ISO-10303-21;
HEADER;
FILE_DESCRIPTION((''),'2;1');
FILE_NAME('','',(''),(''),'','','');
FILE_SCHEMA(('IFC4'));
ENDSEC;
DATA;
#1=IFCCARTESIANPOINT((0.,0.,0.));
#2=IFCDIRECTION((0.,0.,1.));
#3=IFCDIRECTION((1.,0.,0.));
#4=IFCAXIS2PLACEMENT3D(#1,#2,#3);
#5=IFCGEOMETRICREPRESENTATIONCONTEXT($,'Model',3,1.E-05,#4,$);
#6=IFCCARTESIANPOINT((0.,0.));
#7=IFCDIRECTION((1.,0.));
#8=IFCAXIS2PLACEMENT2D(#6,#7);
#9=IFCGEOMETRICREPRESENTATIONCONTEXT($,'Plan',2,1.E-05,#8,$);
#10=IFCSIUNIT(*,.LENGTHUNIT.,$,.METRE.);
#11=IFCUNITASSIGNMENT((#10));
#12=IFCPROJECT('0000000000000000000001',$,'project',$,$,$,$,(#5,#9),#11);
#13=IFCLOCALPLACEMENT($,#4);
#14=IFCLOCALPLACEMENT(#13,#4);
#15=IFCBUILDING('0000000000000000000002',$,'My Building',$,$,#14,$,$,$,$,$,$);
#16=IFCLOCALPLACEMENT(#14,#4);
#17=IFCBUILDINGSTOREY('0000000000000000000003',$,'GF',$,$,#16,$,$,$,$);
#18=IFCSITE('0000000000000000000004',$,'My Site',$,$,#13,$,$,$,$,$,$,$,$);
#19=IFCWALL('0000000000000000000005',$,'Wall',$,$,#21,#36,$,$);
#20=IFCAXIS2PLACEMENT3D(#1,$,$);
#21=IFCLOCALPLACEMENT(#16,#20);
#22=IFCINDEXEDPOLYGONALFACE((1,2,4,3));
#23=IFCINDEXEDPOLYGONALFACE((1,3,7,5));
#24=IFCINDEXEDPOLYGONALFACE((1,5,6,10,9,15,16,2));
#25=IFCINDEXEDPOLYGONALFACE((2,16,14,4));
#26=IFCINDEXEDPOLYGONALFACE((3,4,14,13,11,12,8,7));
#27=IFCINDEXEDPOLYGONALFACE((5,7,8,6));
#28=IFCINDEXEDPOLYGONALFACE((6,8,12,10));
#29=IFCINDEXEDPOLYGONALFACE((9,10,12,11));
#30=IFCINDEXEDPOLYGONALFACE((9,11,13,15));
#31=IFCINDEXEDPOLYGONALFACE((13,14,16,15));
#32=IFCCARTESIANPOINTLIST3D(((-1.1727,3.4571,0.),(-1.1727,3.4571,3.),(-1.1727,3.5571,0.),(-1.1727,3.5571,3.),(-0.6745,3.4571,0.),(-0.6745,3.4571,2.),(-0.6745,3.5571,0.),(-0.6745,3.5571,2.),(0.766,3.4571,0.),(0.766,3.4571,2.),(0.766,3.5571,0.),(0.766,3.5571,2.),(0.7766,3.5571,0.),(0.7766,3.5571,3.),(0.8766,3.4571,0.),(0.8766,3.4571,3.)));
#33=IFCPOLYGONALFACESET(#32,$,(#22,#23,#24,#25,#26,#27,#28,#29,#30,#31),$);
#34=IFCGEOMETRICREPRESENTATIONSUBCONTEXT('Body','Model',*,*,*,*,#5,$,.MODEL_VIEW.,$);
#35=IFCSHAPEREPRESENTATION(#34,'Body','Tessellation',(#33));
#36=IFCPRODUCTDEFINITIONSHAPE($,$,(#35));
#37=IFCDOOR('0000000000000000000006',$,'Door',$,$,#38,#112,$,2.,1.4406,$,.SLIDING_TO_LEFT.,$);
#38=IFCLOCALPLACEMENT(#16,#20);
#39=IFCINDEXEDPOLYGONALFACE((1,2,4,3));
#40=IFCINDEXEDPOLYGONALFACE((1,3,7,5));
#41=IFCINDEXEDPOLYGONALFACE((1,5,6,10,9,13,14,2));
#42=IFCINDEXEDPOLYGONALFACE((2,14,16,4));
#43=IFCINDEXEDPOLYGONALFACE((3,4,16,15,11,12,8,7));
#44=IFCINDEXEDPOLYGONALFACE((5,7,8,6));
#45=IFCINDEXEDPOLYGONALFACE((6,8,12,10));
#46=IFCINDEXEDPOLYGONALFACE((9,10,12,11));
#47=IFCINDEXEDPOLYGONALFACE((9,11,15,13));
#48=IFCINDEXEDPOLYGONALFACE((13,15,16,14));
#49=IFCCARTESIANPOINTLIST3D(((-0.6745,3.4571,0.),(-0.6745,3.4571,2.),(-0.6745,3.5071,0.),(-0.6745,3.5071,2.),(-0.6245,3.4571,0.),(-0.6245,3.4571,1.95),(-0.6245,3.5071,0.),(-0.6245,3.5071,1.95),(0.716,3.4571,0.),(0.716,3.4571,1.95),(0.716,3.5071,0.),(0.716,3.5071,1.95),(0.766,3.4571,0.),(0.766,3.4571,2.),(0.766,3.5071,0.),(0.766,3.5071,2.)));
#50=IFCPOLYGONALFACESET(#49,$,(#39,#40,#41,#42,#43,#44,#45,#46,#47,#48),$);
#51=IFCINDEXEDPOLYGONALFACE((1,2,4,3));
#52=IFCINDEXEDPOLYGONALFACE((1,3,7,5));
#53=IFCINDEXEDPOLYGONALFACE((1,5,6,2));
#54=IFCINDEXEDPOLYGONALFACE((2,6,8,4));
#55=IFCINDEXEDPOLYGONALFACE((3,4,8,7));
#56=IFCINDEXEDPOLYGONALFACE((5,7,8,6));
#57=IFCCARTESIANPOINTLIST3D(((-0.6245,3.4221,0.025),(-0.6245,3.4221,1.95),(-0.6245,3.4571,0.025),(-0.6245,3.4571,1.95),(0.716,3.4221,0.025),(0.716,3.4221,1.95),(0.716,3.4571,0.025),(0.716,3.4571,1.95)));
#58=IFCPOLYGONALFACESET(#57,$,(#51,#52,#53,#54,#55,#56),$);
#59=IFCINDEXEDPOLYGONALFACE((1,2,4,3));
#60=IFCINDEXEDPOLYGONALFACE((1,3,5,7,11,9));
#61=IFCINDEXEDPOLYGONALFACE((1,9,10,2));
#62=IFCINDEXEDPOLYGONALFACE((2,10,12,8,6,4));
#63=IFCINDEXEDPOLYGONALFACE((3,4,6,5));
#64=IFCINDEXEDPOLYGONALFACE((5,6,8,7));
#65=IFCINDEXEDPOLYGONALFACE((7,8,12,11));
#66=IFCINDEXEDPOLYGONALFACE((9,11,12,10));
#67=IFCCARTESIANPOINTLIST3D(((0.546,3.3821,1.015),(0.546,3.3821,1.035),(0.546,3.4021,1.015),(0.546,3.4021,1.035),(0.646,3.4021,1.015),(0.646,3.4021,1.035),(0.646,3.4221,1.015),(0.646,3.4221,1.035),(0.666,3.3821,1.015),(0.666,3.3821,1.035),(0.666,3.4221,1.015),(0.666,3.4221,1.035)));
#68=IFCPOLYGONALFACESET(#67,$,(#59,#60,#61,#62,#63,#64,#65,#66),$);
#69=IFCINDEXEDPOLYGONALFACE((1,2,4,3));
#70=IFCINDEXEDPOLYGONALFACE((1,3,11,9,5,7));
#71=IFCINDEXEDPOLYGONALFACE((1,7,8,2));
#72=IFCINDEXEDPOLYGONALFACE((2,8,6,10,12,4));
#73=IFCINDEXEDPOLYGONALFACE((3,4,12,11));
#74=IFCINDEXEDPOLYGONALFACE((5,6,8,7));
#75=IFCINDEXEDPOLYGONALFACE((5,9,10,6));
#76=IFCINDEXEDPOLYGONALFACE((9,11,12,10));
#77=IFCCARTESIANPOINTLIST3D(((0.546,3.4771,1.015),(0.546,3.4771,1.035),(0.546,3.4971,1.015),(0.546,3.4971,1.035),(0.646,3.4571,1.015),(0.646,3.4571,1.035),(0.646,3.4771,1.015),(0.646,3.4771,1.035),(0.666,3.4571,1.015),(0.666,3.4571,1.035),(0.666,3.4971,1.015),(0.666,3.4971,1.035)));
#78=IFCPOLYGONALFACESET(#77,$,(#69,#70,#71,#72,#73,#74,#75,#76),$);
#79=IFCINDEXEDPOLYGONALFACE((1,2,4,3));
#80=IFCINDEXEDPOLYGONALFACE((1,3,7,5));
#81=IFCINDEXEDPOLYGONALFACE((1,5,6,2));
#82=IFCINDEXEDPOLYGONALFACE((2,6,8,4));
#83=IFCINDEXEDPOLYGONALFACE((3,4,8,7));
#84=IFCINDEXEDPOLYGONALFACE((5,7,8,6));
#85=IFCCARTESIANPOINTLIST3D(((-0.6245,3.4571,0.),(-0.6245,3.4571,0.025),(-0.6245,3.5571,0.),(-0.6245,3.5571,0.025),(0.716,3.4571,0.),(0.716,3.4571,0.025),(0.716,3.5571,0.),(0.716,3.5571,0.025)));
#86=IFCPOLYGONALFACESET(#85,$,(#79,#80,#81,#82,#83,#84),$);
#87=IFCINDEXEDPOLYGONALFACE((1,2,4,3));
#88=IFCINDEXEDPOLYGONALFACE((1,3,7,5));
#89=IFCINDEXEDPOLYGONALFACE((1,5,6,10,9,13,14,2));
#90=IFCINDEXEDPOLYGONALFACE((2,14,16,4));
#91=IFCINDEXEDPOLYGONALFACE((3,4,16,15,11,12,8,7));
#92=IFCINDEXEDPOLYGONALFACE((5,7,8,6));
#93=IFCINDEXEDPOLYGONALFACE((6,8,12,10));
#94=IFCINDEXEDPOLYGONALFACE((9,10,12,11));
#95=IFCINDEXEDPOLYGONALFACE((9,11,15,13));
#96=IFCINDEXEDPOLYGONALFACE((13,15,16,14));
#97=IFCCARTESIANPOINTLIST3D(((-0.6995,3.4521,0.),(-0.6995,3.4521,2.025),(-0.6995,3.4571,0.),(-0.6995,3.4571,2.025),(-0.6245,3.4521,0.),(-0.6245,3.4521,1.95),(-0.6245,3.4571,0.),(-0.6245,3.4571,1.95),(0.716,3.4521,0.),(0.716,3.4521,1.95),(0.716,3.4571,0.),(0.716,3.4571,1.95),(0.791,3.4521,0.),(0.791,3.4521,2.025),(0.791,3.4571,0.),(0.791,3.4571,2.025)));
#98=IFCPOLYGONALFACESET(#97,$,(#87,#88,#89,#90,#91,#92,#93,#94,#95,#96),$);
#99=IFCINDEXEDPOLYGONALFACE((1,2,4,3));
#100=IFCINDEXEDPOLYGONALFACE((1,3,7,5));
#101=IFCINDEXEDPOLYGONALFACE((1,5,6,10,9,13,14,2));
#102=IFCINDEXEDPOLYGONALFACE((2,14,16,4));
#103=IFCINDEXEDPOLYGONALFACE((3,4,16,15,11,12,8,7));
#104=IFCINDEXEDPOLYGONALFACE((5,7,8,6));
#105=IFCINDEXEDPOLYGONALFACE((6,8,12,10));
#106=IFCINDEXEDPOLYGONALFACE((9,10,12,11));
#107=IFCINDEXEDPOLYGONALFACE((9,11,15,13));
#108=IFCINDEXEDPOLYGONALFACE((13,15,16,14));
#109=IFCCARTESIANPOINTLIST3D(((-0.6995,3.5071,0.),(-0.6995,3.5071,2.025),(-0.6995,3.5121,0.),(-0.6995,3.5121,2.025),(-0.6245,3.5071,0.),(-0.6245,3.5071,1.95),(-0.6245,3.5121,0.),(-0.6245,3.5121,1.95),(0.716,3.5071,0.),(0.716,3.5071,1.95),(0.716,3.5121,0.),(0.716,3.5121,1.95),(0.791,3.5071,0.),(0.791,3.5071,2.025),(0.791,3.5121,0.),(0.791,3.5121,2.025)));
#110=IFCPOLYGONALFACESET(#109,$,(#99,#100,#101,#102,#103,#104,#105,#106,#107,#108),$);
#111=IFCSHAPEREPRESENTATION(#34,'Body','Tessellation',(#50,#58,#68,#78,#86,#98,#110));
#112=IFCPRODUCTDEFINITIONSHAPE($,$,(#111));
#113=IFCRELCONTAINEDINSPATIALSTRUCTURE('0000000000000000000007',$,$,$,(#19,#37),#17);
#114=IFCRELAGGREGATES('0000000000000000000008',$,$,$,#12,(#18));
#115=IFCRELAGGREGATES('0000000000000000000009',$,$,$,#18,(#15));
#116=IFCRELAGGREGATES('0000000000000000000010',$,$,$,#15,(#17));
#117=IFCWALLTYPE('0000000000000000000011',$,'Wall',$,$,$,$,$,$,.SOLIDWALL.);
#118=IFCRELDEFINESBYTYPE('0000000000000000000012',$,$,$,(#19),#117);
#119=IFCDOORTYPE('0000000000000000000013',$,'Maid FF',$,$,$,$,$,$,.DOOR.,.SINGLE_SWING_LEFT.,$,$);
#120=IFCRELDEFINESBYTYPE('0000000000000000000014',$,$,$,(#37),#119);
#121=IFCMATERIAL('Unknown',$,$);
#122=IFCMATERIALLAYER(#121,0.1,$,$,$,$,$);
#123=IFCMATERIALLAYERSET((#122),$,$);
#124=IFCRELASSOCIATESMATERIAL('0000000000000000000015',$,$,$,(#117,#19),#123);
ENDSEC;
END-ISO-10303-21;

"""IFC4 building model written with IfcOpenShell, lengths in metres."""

from ifc_helpers import new_model, entity, si_unit, frame, origin_with_axes, origin_2d_with_axis, place, context, subcontext, project, spatial, line, indexed_curve, outline, extrude, shape, source, transform, mapped, material, layer, layer_set, layer_usage, type_object, type_shapes, element, fill, save


model = new_model("IFC4")

# Units and contexts
model_context = context("Model", 3, precision=1e-05, world=origin_with_axes())
plan_context = context("Plan", 2, precision=1e-05, world=origin_2d_with_axis())
body_context_1 = subcontext(model_context, "Body", "Model", "MODEL_VIEW")
body_context_2 = subcontext(plan_context, "Body", "Plan", "PLAN_VIEW")
ifc_project = project(units=[si_unit("LENGTHUNIT", "METRE")], contexts=[model_context, plan_context])

# Site, building, storey
site_placement = place(None, origin_with_axes())
site = spatial("IfcSite", under=ifc_project, at=site_placement, Name="My Site")
building_placement = place(site_placement, origin_with_axes())
building = spatial("IfcBuilding", under=site, at=building_placement, Name="My Building")
storey_placement = place(building_placement, origin_with_axes())
storey = spatial("IfcBuildingStorey", under=building, at=storey_placement, Name="GF")

# Shared definitions
ifc_material = material(Name="Unknown")

# Shared definitions
ifc_layer_1 = layer(ifc_material, 0.1)
ifc_layer_set_1 = layer_set([ifc_layer_1])
wall_type = type_object("IfcWallType", Name="Wall", PredefinedType="SOLIDWALL", material=ifc_layer_set_1)

# Wall, opening, door
ifc_layer_usage_1 = layer_usage(ifc_layer_set_1, "AXIS2", "POSITIVE", 0.0)
wall_1_placement = place(storey_placement, frame((0.7766, 3.5571, 0.0), z_axis=(0.0, 0.0, 1.0), x_axis=(-1.0, 0.0, 0.0)))
wall_1 = element("IfcWall", 1, at=wall_1_placement, inside=storey, type_object=wall_type, material=ifc_layer_usage_1, Name="Wall", context=body_context_1, shape_type="SweptSolid", body=[
    extrude(outline(indexed_curve([(0.0, 0.0), (-0.1, 0.1), (1.9493, 0.1), (1.9493, 0.0)], segments=[line(1, 2, 3, 4, 1)])), origin_with_axes(), (0.0, 0.0, 1.0), 3.0),
])
shared_shape_1 = source(origin_with_axes(), body_context_1, "Body", "SweptSolid", [
    extrude(outline(indexed_curve([(0.0, 0.0), (1.4406, 0.0), (1.4406, 2.0), (0.0, 2.0)], segments=[line(1, 2, 3, 4, 1)])), frame((0.0, -0.6, 0.0), z_axis=(0.0, -1.0, 0.0), x_axis=(1.0, 0.0, 0.0)), (0.0, 0.0, -1.0), 1.2),
])
opening_1_placement = place(wall_1_placement, frame((1.4511, 0.1, 0.0), z_axis=(0.0, 0.0, 1.0), x_axis=(-1.0, 0.000001, 0.0)))
opening_1 = element("IfcOpeningElement", 2, at=opening_1_placement, cuts=wall_1, PredefinedType="OPENING", context=body_context_1, shape_type="MappedRepresentation", body=[
    mapped(shared_shape_1, transform((0.0, 0.0, 0.0), x_axis=(1.0, 0.0, 0.0), y_axis=(0.0, 1.0, 0.0), z_axis=(0.0, 0.0, 1.0), scale=1.0)),
])
door_type_1 = type_object("IfcDoorType", Name="Maid FF", OperationType="SINGLE_SWING_LEFT", PredefinedType="DOOR")
shared_shape_2 = source(origin_with_axes(), body_context_1, "Body", "SweptSolid", [
    extrude(outline(indexed_curve([(0.0, 0.0), (0.0, 2.0), (1.4406, 2.0), (1.4406, 0.0), (1.3906, 0.0), (1.3906, 1.95), (0.05, 1.95), (0.05, 0.0)], segments=[line(1, 2, 3, 4, 5, 6, 7, 8, 1)])), frame((0.0, 0.0, 0.0), z_axis=(0.0, -1.0, 0.0), x_axis=(1.0, 0.0, 0.0)), (0.0, 0.0, -1.0), 0.05),
    extrude(outline(indexed_curve([(0.0, 0.0), (1.3406, 0.0), (1.3406, 0.035), (0.0, 0.035)], segments=[line(1, 2, 3, 4, 1)])), frame((0.05, -0.035, 0.025), z_axis=(0.0, 0.0, 1.0), x_axis=(1.0, 0.0, 0.0)), (0.0, 0.0, 1.0), 1.925),
    extrude(outline(indexed_curve([(0.0, 0.0), (0.0, -0.04), (-0.12, -0.04), (-0.12, -0.02), (-0.02, -0.02), (-0.02, 0.0)], segments=[line(1, 2, 3, 4, 5, 6, 1)])), frame((1.3406, -0.035, 1.015), z_axis=(0.0, 0.0, 1.0), x_axis=(1.0, 0.0, 0.0)), (0.0, 0.0, 1.0), 0.02),
    extrude(outline(indexed_curve([(0.0, 0.0), (0.0, 0.04), (-0.12, 0.04), (-0.12, 0.02), (-0.02, 0.02), (-0.02, 0.0)], segments=[line(1, 2, 3, 4, 5, 6, 1)])), frame((1.3406, 0.0, 1.015), z_axis=(0.0, 0.0, 1.0), x_axis=(1.0, 0.0, 0.0)), (0.0, 0.0, 1.0), 0.02),
    extrude(outline(indexed_curve([(0.0, 0.0), (1.3406, 0.0), (1.3406, 0.1), (0.0, 0.1)], segments=[line(1, 2, 3, 4, 1)])), frame((0.05, 0.0, 0.0), z_axis=(0.0, 0.0, 1.0), x_axis=(1.0, 0.0, 0.0)), (0.0, 0.0, 1.0), 0.025),
    extrude(outline(indexed_curve([(0.0, 0.0), (0.0, 2.025), (1.4906, 2.025), (1.4906, 0.0), (1.4156, 0.0), (1.4156, 1.95), (0.075, 1.95), (0.075, 0.0)], segments=[line(1, 2, 3, 4, 5, 6, 7, 8, 1)])), frame((-0.025, -0.005, 0.0), z_axis=(0.0, -1.0, 0.0), x_axis=(1.0, 0.0, 0.0)), (0.0, 0.0, -1.0), 0.005),
    extrude(outline(indexed_curve([(0.0, 0.0), (0.0, 2.025), (1.4906, 2.025), (1.4906, 0.0), (1.4156, 0.0), (1.4156, 1.95), (0.075, 1.95), (0.075, 0.0)], segments=[line(1, 2, 3, 4, 5, 6, 7, 8, 1)])), frame((-0.025, 0.05, 0.0), z_axis=(0.0, -1.0, 0.0), x_axis=(1.0, 0.0, 0.0)), (0.0, 0.0, -1.0), 0.005),
])
shared_shape_3 = source(origin_with_axes(), body_context_2, "Body", "Curve2D", [
    entity("IfcIndexedPolyCurve", entity("IfcCartesianPointList2D", [[0.0, 0.0], [0.05, 0.0], [0.05, 0.05], [0.0, 0.05]]), [entity("IfcLineIndex", [1, 2, 3, 4, 1])]),
    entity("IfcIndexedPolyCurve", entity("IfcCartesianPointList2D", [[1.4406, 0.0], [1.3906, 0.0], [1.3906, 0.05], [1.4406, 0.05]]), [entity("IfcLineIndex", [1, 2, 3, 4, 1])]),
    entity("IfcIndexedPolyCurve", entity("IfcCartesianPointList2D", [[-0.6203, -0.035], [0.7203, -0.035], [0.7203, 0.0], [-0.6203, 0.0]]), [entity("IfcLineIndex", [1, 2, 3, 4, 1])]),
])
type_shapes(door_type_1, [shared_shape_2, shared_shape_3])
door_1_placement = place(opening_1_placement, frame((0.0, 0.0, 0.0), z_axis=(0.0, 0.0, 1.0), x_axis=(1.0, 0.0, 0.0)))
door_1 = element("IfcDoor", 3, at=door_1_placement, inside=storey, type_object=door_type_1, Name="Door", OperationType="SLIDING_TO_LEFT", OverallHeight=2.0, OverallWidth=1.4406, shapes=[
    shape(body_context_1, "Body", "MappedRepresentation", [mapped(shared_shape_2, transform((0.0, 0.0, 0.0), x_axis=(1.0, 0.0, 0.0), y_axis=(0.0, 1.0, 0.0), z_axis=(0.0, 0.0, 1.0), scale=1.0))]),
    shape(body_context_2, "Body", "MappedRepresentation", [mapped(shared_shape_3, transform((0.0, 0.0, 0.0), x_axis=(1.0, 0.0, 0.0), y_axis=(0.0, 1.0, 0.0), z_axis=(0.0, 0.0, 1.0), scale=1.0))]),
])
fill(opening_1, door_1)

save(model, "model.ifc")
